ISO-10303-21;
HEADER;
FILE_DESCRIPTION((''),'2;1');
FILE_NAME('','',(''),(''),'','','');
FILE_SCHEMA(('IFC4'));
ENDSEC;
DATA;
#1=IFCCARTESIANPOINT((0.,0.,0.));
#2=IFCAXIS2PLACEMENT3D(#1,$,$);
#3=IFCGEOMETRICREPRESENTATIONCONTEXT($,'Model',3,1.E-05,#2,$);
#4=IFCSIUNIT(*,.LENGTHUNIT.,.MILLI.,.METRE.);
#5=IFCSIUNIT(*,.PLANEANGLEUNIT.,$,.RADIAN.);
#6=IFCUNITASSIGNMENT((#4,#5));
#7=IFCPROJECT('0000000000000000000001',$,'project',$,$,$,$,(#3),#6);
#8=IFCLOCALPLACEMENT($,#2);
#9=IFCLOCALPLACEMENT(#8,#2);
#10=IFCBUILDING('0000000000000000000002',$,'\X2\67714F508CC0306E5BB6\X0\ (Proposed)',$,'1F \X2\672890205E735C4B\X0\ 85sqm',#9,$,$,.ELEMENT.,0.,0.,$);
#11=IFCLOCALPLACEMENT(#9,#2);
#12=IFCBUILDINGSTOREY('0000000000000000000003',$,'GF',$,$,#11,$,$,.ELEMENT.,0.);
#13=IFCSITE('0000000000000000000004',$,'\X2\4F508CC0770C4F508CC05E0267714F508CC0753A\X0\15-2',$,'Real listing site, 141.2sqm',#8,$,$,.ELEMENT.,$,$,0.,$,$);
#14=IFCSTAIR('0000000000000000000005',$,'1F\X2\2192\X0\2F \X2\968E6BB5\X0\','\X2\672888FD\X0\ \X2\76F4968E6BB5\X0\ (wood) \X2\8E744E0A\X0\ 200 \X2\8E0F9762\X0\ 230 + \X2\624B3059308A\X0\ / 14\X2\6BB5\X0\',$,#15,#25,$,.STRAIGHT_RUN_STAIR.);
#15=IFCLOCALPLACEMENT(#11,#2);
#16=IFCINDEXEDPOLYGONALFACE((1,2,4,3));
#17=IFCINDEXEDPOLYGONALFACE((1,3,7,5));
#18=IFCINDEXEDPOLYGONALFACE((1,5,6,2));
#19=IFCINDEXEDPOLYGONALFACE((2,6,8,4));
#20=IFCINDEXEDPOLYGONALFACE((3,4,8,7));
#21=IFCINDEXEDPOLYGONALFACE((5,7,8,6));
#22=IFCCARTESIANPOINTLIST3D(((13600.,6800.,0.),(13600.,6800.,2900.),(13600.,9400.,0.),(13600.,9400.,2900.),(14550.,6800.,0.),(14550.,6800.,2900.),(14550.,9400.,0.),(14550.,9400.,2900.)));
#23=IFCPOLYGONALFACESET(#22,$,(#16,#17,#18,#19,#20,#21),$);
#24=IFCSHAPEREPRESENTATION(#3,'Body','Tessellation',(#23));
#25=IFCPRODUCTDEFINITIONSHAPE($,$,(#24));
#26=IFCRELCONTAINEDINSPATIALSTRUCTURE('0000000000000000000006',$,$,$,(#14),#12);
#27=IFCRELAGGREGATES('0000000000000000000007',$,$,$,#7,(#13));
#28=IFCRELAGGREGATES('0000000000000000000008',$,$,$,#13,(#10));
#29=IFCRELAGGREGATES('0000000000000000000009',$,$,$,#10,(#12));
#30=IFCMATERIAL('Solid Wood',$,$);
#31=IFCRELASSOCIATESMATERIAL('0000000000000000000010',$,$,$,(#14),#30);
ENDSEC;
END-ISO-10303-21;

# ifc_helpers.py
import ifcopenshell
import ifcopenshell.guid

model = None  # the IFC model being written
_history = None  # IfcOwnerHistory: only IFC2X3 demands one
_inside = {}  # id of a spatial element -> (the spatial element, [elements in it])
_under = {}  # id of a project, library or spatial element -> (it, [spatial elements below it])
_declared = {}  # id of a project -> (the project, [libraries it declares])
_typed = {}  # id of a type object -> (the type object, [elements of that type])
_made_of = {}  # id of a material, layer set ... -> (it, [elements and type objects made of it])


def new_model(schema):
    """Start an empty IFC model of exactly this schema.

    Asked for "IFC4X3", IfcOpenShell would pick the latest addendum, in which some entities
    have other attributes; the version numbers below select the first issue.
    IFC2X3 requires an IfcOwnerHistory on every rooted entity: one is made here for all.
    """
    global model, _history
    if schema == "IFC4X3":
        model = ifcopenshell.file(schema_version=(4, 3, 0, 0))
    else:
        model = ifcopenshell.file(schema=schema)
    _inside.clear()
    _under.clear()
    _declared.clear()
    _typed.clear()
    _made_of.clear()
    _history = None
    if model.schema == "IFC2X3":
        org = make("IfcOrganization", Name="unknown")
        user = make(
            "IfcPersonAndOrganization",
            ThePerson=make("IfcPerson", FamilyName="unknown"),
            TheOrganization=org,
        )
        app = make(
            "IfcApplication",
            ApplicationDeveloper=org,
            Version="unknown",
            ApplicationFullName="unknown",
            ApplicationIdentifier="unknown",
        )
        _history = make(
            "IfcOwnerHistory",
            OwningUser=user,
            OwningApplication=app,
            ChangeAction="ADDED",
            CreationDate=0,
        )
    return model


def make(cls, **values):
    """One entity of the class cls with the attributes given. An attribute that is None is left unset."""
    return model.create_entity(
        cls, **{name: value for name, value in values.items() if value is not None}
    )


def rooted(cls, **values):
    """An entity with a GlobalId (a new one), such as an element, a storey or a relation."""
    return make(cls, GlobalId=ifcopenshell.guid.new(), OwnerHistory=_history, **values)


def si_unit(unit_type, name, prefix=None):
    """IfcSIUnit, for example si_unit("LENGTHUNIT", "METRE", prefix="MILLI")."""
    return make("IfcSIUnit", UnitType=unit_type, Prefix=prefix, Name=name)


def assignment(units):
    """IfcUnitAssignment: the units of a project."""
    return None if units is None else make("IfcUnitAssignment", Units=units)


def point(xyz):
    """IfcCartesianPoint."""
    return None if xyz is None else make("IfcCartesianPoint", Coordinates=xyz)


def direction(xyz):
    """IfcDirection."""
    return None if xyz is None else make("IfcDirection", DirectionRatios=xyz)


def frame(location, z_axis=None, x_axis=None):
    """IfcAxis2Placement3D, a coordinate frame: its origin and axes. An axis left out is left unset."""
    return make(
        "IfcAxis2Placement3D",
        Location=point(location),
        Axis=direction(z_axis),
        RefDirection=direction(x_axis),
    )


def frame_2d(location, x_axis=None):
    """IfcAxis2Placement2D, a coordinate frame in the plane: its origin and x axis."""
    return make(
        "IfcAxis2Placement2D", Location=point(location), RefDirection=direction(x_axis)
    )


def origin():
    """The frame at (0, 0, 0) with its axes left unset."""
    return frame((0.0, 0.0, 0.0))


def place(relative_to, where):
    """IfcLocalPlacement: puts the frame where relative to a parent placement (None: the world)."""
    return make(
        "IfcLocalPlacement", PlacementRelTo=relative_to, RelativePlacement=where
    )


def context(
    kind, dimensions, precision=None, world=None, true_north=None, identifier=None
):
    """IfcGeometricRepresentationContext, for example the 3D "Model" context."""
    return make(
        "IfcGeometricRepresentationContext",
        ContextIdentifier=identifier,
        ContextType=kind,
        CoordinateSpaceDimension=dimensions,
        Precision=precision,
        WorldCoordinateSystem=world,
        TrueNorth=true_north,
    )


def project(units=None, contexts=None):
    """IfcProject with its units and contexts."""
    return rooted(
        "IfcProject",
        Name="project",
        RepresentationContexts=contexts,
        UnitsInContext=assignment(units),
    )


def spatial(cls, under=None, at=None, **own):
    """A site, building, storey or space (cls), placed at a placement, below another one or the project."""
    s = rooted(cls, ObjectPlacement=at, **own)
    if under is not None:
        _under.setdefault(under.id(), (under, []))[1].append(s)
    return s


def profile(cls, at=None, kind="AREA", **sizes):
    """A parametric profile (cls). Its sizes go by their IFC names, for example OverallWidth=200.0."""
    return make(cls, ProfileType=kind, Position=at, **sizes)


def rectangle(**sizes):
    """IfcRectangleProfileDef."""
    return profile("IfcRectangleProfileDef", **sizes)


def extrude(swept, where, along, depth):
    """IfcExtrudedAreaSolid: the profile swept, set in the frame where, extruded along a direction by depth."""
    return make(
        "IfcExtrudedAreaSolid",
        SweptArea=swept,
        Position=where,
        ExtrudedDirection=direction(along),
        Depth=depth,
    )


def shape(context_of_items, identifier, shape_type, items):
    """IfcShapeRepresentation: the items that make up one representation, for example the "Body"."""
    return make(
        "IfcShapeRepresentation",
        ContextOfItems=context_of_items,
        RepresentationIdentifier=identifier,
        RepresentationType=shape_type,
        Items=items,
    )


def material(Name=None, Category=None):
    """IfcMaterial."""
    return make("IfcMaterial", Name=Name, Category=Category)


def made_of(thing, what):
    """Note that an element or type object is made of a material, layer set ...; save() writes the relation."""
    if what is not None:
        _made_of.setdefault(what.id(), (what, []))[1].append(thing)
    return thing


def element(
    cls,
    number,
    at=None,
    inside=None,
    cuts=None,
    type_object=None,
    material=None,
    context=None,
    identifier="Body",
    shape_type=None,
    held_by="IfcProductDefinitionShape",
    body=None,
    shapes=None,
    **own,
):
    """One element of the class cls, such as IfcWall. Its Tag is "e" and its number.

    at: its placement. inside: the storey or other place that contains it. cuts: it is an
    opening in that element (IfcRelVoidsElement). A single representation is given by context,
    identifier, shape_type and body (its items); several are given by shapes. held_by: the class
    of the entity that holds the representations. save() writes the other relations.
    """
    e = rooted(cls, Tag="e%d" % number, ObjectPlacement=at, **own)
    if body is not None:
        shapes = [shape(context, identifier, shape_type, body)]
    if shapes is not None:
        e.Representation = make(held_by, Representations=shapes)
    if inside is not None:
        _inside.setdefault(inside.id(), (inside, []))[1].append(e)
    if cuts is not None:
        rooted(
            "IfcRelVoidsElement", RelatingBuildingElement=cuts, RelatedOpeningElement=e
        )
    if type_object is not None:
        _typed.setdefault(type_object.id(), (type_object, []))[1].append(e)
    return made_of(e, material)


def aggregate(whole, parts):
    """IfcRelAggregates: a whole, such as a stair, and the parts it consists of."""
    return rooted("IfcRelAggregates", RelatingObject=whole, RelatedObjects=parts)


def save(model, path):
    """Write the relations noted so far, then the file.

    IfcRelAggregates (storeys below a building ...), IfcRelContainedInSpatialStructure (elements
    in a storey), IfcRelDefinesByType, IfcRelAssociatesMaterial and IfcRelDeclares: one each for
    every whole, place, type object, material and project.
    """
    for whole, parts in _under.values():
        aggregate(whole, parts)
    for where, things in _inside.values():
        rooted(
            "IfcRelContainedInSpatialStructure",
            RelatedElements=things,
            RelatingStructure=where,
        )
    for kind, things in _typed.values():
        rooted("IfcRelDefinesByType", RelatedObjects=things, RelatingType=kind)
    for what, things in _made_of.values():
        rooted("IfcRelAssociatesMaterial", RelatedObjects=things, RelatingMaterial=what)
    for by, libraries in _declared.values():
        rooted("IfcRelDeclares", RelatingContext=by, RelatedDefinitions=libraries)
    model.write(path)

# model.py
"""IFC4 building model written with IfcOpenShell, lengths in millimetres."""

from ifc_helpers import new_model, si_unit, frame, frame_2d, origin, place, context, project, spatial, rectangle, extrude, material, element, save


model = new_model("IFC4")

# Units and contexts
model_context = context("Model", 3, precision=1e-05, world=origin())
ifc_project = project(units=[si_unit("LENGTHUNIT", "METRE", prefix="MILLI"), si_unit("PLANEANGLEUNIT", "RADIAN")], contexts=[model_context])

# Site, building, storey
site_placement = place(None, origin())
site = spatial("IfcSite", under=ifc_project, at=site_placement, Name="佐賀県佐賀市東佐賀町15-2", ObjectType="Real listing site, 141.2sqm", CompositionType="ELEMENT", RefElevation=0.0)
building_placement = place(site_placement, origin())
building = spatial("IfcBuilding", under=site, at=building_placement, Name="東佐賀の家 (Proposed)", ObjectType="1F 木造平屋 85sqm", CompositionType="ELEMENT", ElevationOfRefHeight=0.0, ElevationOfTerrain=0.0)
storey_placement = place(building_placement, origin())
storey = spatial("IfcBuildingStorey", under=building, at=storey_placement, Name="GF", CompositionType="ELEMENT", Elevation=0.0)

# Shared definitions
ifc_material_1 = material(Name="Solid Wood")

# Stair
stair_placement = place(storey_placement, frame((6800.0, 3400.0, 0.0)))
element("IfcStair", 1, at=stair_placement, inside=storey, material=ifc_material_1, Name="1F→2F 階段", Description="木製 直階段 (wood) 蹴上 200 踏面 230 + 手すり / 14段", PredefinedType="STRAIGHT_RUN_STAIR", context=model_context, shape_type="SweptSolid", body=[
    extrude(rectangle(XDim=950.0, YDim=2600.0, at=frame_2d((475.0, 1300.0))), frame((6800.0, 3400.0, 0.0)), (0.0, 0.0, 1.0), 2900.0),
])

save(model, "model.ifc")
